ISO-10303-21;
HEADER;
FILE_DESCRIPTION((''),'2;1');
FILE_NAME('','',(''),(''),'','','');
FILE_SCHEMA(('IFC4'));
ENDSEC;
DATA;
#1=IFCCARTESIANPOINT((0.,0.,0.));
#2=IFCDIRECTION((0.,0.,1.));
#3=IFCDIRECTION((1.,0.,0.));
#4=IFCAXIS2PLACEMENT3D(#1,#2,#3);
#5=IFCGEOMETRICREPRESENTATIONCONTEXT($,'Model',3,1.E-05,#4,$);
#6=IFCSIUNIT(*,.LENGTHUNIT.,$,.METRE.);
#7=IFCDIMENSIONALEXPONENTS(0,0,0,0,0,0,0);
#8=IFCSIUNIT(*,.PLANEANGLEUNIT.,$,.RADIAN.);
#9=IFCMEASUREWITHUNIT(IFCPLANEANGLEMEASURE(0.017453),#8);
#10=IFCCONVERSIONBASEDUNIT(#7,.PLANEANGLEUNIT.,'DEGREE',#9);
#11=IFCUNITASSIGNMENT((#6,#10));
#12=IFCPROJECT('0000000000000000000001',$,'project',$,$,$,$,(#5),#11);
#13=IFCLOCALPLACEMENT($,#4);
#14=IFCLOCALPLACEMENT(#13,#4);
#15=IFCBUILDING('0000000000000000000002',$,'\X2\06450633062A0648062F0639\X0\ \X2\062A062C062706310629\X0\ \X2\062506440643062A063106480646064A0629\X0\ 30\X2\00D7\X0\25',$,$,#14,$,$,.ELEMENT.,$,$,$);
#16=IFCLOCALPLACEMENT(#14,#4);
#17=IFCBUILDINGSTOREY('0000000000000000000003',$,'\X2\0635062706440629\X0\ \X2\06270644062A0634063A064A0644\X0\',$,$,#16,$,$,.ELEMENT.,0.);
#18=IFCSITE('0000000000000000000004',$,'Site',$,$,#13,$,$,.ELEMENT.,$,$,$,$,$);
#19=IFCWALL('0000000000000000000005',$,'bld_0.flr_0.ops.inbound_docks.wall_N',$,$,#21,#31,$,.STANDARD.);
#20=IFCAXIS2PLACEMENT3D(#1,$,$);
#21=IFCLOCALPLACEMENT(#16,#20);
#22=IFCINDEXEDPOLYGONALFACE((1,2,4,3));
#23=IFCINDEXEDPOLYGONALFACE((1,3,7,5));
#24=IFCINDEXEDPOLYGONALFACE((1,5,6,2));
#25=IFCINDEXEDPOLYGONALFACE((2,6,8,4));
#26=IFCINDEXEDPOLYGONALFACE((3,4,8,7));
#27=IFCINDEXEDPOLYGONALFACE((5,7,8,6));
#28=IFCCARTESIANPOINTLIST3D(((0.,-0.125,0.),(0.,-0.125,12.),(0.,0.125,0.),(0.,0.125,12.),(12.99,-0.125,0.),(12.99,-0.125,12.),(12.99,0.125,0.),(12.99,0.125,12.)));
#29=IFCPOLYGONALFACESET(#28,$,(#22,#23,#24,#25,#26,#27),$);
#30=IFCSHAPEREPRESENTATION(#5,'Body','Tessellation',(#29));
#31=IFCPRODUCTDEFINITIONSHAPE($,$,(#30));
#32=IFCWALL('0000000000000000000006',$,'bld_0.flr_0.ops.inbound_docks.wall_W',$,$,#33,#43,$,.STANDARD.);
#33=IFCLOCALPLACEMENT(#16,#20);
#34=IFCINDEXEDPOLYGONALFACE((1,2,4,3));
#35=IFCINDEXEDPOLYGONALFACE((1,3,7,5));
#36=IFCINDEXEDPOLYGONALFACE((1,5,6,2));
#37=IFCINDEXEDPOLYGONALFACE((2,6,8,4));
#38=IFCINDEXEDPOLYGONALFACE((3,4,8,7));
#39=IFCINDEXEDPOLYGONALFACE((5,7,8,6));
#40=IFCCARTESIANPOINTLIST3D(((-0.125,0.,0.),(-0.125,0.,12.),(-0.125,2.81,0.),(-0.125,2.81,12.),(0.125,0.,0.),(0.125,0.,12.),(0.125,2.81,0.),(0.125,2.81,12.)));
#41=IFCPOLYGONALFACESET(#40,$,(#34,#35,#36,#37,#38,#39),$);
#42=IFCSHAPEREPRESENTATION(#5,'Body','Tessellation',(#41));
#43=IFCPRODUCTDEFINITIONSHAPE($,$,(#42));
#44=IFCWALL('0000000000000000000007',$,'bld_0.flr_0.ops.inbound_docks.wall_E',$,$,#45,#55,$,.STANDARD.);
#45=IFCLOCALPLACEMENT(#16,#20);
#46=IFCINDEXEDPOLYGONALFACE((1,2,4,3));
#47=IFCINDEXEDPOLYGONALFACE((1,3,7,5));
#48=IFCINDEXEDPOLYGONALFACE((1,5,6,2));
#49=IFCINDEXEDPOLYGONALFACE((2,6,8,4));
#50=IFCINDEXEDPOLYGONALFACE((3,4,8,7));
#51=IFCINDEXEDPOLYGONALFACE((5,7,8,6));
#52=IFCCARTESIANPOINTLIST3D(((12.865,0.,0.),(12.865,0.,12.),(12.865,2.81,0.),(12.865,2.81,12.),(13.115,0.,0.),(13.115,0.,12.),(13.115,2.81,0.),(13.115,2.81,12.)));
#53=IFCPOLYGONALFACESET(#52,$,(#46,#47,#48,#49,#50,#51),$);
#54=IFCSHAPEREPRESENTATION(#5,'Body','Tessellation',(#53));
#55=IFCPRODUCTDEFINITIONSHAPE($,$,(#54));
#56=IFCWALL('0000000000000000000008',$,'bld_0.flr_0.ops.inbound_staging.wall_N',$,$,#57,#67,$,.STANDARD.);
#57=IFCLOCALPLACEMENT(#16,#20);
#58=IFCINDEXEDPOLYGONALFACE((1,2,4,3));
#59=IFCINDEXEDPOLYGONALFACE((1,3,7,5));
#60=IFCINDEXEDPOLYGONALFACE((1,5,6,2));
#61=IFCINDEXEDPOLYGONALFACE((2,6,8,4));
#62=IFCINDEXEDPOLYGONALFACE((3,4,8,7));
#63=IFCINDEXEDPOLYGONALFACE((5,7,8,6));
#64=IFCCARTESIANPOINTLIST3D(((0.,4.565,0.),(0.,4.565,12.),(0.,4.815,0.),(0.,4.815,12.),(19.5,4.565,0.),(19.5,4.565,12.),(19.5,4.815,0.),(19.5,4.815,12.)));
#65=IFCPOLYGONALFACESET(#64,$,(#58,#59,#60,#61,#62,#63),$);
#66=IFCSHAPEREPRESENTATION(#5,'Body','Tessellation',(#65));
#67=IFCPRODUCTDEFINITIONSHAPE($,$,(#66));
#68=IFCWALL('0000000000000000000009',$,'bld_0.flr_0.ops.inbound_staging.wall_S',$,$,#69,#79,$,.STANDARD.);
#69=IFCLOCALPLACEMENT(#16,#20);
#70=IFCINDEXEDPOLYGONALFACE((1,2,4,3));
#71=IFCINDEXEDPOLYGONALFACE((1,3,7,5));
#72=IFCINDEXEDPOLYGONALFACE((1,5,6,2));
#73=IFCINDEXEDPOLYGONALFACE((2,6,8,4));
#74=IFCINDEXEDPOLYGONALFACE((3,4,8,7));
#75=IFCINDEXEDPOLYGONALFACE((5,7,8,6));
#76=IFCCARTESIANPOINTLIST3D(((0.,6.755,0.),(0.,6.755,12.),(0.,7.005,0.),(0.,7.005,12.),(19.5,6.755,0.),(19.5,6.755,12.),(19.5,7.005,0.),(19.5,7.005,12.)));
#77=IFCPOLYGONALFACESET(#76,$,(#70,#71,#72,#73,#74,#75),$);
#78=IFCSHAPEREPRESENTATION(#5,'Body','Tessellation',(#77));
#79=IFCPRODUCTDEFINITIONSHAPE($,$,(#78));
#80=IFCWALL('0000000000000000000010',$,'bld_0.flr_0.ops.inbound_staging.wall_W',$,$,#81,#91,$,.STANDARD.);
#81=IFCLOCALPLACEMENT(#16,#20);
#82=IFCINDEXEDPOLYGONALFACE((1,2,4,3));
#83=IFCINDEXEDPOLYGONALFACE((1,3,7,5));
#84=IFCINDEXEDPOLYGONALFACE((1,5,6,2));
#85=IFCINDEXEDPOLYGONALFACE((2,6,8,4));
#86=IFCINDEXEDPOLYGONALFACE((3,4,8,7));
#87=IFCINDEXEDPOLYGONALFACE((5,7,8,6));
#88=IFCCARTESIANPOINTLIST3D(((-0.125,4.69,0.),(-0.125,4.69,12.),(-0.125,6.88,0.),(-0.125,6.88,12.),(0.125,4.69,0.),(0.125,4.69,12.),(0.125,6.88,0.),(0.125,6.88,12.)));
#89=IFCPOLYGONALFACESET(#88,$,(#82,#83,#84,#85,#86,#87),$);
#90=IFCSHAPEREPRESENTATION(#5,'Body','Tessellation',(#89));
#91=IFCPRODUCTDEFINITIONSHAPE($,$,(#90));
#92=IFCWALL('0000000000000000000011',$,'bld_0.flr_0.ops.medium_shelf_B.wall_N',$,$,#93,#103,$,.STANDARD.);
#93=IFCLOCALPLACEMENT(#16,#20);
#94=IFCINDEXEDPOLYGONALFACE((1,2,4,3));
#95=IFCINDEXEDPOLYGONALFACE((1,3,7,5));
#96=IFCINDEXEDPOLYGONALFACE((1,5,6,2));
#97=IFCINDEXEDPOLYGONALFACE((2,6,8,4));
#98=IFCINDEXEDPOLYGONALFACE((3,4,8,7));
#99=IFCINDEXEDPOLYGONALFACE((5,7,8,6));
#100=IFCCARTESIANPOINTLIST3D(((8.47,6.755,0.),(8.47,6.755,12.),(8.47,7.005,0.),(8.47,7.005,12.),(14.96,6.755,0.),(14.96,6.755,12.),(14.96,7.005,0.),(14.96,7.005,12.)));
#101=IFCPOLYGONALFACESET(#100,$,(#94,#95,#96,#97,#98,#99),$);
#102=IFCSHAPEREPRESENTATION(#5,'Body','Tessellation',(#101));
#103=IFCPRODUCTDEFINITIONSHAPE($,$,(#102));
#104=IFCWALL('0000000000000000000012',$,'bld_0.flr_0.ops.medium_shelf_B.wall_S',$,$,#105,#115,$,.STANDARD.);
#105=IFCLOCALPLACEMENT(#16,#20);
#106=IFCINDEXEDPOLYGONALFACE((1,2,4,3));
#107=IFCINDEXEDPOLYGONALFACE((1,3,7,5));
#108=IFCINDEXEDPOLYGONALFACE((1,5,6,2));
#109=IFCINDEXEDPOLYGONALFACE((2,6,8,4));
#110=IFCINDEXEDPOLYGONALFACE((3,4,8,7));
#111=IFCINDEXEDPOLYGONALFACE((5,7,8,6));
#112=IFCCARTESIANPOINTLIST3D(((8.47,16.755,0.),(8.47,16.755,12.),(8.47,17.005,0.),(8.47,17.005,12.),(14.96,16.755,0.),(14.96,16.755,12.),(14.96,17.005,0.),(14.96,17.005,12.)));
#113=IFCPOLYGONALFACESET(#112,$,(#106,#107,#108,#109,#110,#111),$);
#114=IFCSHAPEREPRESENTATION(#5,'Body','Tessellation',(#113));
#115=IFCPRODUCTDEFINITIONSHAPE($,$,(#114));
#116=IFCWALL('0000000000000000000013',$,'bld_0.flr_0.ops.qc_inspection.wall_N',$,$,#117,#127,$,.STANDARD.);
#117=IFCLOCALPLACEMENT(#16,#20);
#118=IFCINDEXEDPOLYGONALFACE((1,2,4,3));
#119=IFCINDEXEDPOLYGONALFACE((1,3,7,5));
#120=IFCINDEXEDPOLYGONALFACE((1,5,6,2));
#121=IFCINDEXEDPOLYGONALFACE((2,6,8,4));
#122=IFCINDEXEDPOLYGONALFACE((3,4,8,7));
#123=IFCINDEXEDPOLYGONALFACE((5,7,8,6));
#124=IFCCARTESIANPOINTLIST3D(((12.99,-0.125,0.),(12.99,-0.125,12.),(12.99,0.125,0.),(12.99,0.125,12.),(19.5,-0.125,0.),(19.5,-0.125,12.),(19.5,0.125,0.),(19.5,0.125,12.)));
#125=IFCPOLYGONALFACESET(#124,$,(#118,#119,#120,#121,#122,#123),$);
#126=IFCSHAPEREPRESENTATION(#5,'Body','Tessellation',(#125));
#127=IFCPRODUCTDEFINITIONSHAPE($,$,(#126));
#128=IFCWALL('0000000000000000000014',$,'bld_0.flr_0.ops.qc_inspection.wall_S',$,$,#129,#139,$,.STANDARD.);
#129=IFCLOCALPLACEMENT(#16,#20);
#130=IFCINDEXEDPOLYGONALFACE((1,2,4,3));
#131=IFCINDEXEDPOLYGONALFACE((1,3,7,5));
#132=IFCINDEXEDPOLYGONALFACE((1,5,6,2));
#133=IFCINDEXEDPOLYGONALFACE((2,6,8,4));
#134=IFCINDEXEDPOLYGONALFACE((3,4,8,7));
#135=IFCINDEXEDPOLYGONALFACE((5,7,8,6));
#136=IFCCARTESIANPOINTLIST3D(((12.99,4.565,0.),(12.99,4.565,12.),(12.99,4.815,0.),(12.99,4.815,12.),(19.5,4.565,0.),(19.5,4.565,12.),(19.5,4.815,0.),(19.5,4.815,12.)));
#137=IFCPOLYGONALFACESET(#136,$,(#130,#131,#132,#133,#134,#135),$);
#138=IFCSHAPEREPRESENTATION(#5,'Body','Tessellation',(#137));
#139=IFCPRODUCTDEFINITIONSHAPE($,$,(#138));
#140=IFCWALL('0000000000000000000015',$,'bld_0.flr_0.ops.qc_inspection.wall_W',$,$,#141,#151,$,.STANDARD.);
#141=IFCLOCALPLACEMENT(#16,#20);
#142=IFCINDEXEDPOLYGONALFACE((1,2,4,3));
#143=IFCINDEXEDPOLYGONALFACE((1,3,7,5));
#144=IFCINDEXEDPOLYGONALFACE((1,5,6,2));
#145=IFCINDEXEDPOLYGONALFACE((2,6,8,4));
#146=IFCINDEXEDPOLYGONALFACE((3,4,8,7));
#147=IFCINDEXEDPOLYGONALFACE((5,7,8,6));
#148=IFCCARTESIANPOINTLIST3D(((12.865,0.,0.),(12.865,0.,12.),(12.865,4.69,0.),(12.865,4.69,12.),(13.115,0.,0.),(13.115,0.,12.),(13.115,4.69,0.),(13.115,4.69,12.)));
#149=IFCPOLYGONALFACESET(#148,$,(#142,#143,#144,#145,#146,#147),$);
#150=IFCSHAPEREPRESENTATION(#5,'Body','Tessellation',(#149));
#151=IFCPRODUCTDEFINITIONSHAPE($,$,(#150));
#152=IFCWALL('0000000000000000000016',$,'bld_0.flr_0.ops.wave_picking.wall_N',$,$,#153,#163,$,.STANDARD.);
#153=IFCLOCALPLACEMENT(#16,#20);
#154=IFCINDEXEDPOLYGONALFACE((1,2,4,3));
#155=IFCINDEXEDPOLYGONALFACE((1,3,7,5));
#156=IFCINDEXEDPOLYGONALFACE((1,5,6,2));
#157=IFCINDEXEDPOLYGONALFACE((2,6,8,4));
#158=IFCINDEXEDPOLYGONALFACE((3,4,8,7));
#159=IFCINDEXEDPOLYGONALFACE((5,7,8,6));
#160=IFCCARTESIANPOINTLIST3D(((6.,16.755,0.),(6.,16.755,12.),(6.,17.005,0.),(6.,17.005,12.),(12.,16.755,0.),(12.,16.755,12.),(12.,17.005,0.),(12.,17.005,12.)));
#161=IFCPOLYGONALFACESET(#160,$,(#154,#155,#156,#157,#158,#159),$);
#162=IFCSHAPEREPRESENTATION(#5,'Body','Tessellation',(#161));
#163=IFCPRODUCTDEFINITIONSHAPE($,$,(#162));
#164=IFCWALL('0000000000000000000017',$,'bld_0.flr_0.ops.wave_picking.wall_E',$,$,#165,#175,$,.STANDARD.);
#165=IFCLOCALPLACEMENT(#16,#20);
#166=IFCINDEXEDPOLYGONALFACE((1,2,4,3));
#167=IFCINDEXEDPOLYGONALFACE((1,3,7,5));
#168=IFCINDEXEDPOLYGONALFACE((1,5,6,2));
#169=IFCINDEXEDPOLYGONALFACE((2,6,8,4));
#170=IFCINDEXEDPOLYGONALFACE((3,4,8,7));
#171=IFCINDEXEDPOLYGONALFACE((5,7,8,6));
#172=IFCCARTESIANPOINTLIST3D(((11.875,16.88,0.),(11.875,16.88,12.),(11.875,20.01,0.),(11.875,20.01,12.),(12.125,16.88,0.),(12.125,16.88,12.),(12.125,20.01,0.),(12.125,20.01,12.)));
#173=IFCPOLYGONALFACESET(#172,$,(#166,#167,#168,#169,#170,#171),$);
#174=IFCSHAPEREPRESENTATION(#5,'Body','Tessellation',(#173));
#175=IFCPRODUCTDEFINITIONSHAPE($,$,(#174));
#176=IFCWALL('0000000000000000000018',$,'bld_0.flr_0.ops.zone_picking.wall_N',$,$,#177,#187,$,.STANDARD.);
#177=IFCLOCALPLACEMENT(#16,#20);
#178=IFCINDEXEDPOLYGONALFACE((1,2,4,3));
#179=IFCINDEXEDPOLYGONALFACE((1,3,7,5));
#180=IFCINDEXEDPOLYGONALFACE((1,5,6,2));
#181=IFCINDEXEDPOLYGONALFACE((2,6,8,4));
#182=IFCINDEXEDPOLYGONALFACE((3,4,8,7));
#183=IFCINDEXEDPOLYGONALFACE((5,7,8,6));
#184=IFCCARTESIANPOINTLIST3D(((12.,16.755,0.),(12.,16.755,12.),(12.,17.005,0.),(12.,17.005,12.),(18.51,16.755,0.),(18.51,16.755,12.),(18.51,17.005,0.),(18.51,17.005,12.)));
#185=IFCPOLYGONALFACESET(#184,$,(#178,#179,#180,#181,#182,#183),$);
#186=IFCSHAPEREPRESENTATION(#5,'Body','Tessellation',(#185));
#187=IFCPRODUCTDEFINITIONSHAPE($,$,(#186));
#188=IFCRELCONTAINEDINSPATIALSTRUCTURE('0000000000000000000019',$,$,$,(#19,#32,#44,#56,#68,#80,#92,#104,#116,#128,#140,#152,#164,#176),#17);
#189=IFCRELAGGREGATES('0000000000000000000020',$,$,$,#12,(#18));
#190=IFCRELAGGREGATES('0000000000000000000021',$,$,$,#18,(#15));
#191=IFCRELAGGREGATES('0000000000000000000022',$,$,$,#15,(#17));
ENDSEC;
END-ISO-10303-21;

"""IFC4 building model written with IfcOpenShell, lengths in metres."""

from ifc_helpers import new_model, entity, si_unit, converted_unit, frame, frame_2d, origin_with_axes, place, context, project, spatial, rectangle, extrude, element, save


model = new_model("IFC4")

# Units and contexts
model_context = context("Model", 3, precision=1e-05, world=origin_with_axes())
ifc_project = project(units=[si_unit("LENGTHUNIT", "METRE"), converted_unit("PLANEANGLEUNIT", "DEGREE", entity("IfcPlaneAngleMeasure", 0.017453), si_unit("PLANEANGLEUNIT", "RADIAN"), dimensions=[0, 0, 0, 0, 0, 0, 0])], contexts=[model_context])

# Site, building, storey
site_placement = place(None, origin_with_axes())
site = spatial("IfcSite", under=ifc_project, at=site_placement, Name="Site", CompositionType="ELEMENT")
building_placement = place(site_placement, origin_with_axes())
building = spatial("IfcBuilding", under=site, at=building_placement, Name="مستودع تجارة إلكترونية 30×25", CompositionType="ELEMENT")
storey_placement = place(building_placement, origin_with_axes())
storey = spatial("IfcBuildingStorey", under=building, at=storey_placement, Name="صالة التشغيل", CompositionType="ELEMENT", Elevation=0.0)

# Walls
for number, where, z_axis, x_axis, name in (
    (1, (0.0, 0.0, 0.0), (0.0, 0.0, 1.0), (1.0, 0.0, 0.0), "bld_0.flr_0.ops.inbound_docks.wall_N"),
):
    element("IfcWall", number, at=place(storey_placement, frame(where, z_axis=z_axis, x_axis=x_axis)), inside=storey, Name=name, PredefinedType="STANDARD", context=model_context, shape_type="SweptSolid", body=[
        extrude(rectangle(XDim=12.99, YDim=0.25, at=frame_2d((6.495, 0.0), x_axis=(1.0, 0.0))), origin_with_axes(), (0.0, 0.0, 1.0), 12.0),
    ])
for number, where, z_axis, x_axis, name in (
    (2, (0.0, 0.0, 0.0), (0.0, 0.0, 1.0), (0.0, 1.0, 0.0), "bld_0.flr_0.ops.inbound_docks.wall_W"),
    (3, (12.99, 0.0, 0.0), (0.0, 0.0, 1.0), (0.0, 1.0, 0.0), "bld_0.flr_0.ops.inbound_docks.wall_E"),
):
    element("IfcWall", number, at=place(storey_placement, frame(where, z_axis=z_axis, x_axis=x_axis)), inside=storey, Name=name, PredefinedType="STANDARD", context=model_context, shape_type="SweptSolid", body=[
        extrude(rectangle(XDim=2.81, YDim=0.25, at=frame_2d((1.405, 0.0), x_axis=(1.0, 0.0))), origin_with_axes(), (0.0, 0.0, 1.0), 12.0),
    ])
for number, where, z_axis, x_axis, name in (
    (4, (0.0, 4.69, 0.0), (0.0, 0.0, 1.0), (1.0, 0.0, 0.0), "bld_0.flr_0.ops.inbound_staging.wall_N"),
    (5, (0.0, 6.88, 0.0), (0.0, 0.0, 1.0), (1.0, 0.0, 0.0), "bld_0.flr_0.ops.inbound_staging.wall_S"),
):
    element("IfcWall", number, at=place(storey_placement, frame(where, z_axis=z_axis, x_axis=x_axis)), inside=storey, Name=name, PredefinedType="STANDARD", context=model_context, shape_type="SweptSolid", body=[
        extrude(rectangle(XDim=19.5, YDim=0.25, at=frame_2d((9.75, 0.0), x_axis=(1.0, 0.0))), origin_with_axes(), (0.0, 0.0, 1.0), 12.0),
    ])
wall_1_placement = place(storey_placement, frame((0.0, 4.69, 0.0), z_axis=(0.0, 0.0, 1.0), x_axis=(0.0, 1.0, 0.0)))
element("IfcWall", 6, at=wall_1_placement, inside=storey, Name="bld_0.flr_0.ops.inbound_staging.wall_W", PredefinedType="STANDARD", context=model_context, shape_type="SweptSolid", body=[
    extrude(rectangle(XDim=2.19, YDim=0.25, at=frame_2d((1.095, 0.0), x_axis=(1.0, 0.0))), origin_with_axes(), (0.0, 0.0, 1.0), 12.0),
])
for number, where, z_axis, x_axis, name in (
    (7, (8.47, 6.88, 0.0), (0.0, 0.0, 1.0), (1.0, 0.0, 0.0), "bld_0.flr_0.ops.medium_shelf_B.wall_N"),
    (8, (8.47, 16.88, 0.0), (0.0, 0.0, 1.0), (1.0, 0.0, 0.0), "bld_0.flr_0.ops.medium_shelf_B.wall_S"),
):
    element("IfcWall", number, at=place(storey_placement, frame(where, z_axis=z_axis, x_axis=x_axis)), inside=storey, Name=name, PredefinedType="STANDARD", context=model_context, shape_type="SweptSolid", body=[
        extrude(rectangle(XDim=6.49, YDim=0.25, at=frame_2d((3.245, 0.0), x_axis=(1.0, 0.0))), origin_with_axes(), (0.0, 0.0, 1.0), 12.0),
    ])
for number, where, z_axis, x_axis, name in (
    (9, (12.99, 0.0, 0.0), (0.0, 0.0, 1.0), (1.0, 0.0, 0.0), "bld_0.flr_0.ops.qc_inspection.wall_N"),
    (10, (12.99, 4.69, 0.0), (0.0, 0.0, 1.0), (1.0, 0.0, 0.0), "bld_0.flr_0.ops.qc_inspection.wall_S"),
):
    element("IfcWall", number, at=place(storey_placement, frame(where, z_axis=z_axis, x_axis=x_axis)), inside=storey, Name=name, PredefinedType="STANDARD", context=model_context, shape_type="SweptSolid", body=[
        extrude(rectangle(XDim=6.51, YDim=0.25, at=frame_2d((3.255, 0.0), x_axis=(1.0, 0.0))), origin_with_axes(), (0.0, 0.0, 1.0), 12.0),
    ])
wall_2_placement = place(storey_placement, frame((12.99, 0.0, 0.0), z_axis=(0.0, 0.0, 1.0), x_axis=(0.0, 1.0, 0.0)))
element("IfcWall", 11, at=wall_2_placement, inside=storey, Name="bld_0.flr_0.ops.qc_inspection.wall_W", PredefinedType="STANDARD", context=model_context, shape_type="SweptSolid", body=[
    extrude(rectangle(XDim=4.69, YDim=0.25, at=frame_2d((2.345, 0.0), x_axis=(1.0, 0.0))), origin_with_axes(), (0.0, 0.0, 1.0), 12.0),
])
wall_3_placement = place(storey_placement, frame((6.0, 16.88, 0.0), z_axis=(0.0, 0.0, 1.0), x_axis=(1.0, 0.0, 0.0)))
element("IfcWall", 12, at=wall_3_placement, inside=storey, Name="bld_0.flr_0.ops.wave_picking.wall_N", PredefinedType="STANDARD", context=model_context, shape_type="SweptSolid", body=[
    extrude(rectangle(XDim=6.0, YDim=0.25, at=frame_2d((3.0, 0.0), x_axis=(1.0, 0.0))), origin_with_axes(), (0.0, 0.0, 1.0), 12.0),
])
for number, where, z_axis, x_axis, name in (
    (13, (12.0, 16.88, 0.0), (0.0, 0.0, 1.0), (0.0, 1.0, 0.0), "bld_0.flr_0.ops.wave_picking.wall_E"),
):
    element("IfcWall", number, at=place(storey_placement, frame(where, z_axis=z_axis, x_axis=x_axis)), inside=storey, Name=name, PredefinedType="STANDARD", context=model_context, shape_type="SweptSolid", body=[
        extrude(rectangle(XDim=3.13, YDim=0.25, at=frame_2d((1.565, 0.0), x_axis=(1.0, 0.0))), origin_with_axes(), (0.0, 0.0, 1.0), 12.0),
    ])
wall_4_placement = place(storey_placement, frame((12.0, 16.88, 0.0), z_axis=(0.0, 0.0, 1.0), x_axis=(1.0, 0.0, 0.0)))
element("IfcWall", 14, at=wall_4_placement, inside=storey, Name="bld_0.flr_0.ops.zone_picking.wall_N", PredefinedType="STANDARD", context=model_context, shape_type="SweptSolid", body=[
    extrude(rectangle(XDim=6.51, YDim=0.25, at=frame_2d((3.255, 0.0), x_axis=(1.0, 0.0))), origin_with_axes(), (0.0, 0.0, 1.0), 12.0),
])

save(model, "model.ifc")
